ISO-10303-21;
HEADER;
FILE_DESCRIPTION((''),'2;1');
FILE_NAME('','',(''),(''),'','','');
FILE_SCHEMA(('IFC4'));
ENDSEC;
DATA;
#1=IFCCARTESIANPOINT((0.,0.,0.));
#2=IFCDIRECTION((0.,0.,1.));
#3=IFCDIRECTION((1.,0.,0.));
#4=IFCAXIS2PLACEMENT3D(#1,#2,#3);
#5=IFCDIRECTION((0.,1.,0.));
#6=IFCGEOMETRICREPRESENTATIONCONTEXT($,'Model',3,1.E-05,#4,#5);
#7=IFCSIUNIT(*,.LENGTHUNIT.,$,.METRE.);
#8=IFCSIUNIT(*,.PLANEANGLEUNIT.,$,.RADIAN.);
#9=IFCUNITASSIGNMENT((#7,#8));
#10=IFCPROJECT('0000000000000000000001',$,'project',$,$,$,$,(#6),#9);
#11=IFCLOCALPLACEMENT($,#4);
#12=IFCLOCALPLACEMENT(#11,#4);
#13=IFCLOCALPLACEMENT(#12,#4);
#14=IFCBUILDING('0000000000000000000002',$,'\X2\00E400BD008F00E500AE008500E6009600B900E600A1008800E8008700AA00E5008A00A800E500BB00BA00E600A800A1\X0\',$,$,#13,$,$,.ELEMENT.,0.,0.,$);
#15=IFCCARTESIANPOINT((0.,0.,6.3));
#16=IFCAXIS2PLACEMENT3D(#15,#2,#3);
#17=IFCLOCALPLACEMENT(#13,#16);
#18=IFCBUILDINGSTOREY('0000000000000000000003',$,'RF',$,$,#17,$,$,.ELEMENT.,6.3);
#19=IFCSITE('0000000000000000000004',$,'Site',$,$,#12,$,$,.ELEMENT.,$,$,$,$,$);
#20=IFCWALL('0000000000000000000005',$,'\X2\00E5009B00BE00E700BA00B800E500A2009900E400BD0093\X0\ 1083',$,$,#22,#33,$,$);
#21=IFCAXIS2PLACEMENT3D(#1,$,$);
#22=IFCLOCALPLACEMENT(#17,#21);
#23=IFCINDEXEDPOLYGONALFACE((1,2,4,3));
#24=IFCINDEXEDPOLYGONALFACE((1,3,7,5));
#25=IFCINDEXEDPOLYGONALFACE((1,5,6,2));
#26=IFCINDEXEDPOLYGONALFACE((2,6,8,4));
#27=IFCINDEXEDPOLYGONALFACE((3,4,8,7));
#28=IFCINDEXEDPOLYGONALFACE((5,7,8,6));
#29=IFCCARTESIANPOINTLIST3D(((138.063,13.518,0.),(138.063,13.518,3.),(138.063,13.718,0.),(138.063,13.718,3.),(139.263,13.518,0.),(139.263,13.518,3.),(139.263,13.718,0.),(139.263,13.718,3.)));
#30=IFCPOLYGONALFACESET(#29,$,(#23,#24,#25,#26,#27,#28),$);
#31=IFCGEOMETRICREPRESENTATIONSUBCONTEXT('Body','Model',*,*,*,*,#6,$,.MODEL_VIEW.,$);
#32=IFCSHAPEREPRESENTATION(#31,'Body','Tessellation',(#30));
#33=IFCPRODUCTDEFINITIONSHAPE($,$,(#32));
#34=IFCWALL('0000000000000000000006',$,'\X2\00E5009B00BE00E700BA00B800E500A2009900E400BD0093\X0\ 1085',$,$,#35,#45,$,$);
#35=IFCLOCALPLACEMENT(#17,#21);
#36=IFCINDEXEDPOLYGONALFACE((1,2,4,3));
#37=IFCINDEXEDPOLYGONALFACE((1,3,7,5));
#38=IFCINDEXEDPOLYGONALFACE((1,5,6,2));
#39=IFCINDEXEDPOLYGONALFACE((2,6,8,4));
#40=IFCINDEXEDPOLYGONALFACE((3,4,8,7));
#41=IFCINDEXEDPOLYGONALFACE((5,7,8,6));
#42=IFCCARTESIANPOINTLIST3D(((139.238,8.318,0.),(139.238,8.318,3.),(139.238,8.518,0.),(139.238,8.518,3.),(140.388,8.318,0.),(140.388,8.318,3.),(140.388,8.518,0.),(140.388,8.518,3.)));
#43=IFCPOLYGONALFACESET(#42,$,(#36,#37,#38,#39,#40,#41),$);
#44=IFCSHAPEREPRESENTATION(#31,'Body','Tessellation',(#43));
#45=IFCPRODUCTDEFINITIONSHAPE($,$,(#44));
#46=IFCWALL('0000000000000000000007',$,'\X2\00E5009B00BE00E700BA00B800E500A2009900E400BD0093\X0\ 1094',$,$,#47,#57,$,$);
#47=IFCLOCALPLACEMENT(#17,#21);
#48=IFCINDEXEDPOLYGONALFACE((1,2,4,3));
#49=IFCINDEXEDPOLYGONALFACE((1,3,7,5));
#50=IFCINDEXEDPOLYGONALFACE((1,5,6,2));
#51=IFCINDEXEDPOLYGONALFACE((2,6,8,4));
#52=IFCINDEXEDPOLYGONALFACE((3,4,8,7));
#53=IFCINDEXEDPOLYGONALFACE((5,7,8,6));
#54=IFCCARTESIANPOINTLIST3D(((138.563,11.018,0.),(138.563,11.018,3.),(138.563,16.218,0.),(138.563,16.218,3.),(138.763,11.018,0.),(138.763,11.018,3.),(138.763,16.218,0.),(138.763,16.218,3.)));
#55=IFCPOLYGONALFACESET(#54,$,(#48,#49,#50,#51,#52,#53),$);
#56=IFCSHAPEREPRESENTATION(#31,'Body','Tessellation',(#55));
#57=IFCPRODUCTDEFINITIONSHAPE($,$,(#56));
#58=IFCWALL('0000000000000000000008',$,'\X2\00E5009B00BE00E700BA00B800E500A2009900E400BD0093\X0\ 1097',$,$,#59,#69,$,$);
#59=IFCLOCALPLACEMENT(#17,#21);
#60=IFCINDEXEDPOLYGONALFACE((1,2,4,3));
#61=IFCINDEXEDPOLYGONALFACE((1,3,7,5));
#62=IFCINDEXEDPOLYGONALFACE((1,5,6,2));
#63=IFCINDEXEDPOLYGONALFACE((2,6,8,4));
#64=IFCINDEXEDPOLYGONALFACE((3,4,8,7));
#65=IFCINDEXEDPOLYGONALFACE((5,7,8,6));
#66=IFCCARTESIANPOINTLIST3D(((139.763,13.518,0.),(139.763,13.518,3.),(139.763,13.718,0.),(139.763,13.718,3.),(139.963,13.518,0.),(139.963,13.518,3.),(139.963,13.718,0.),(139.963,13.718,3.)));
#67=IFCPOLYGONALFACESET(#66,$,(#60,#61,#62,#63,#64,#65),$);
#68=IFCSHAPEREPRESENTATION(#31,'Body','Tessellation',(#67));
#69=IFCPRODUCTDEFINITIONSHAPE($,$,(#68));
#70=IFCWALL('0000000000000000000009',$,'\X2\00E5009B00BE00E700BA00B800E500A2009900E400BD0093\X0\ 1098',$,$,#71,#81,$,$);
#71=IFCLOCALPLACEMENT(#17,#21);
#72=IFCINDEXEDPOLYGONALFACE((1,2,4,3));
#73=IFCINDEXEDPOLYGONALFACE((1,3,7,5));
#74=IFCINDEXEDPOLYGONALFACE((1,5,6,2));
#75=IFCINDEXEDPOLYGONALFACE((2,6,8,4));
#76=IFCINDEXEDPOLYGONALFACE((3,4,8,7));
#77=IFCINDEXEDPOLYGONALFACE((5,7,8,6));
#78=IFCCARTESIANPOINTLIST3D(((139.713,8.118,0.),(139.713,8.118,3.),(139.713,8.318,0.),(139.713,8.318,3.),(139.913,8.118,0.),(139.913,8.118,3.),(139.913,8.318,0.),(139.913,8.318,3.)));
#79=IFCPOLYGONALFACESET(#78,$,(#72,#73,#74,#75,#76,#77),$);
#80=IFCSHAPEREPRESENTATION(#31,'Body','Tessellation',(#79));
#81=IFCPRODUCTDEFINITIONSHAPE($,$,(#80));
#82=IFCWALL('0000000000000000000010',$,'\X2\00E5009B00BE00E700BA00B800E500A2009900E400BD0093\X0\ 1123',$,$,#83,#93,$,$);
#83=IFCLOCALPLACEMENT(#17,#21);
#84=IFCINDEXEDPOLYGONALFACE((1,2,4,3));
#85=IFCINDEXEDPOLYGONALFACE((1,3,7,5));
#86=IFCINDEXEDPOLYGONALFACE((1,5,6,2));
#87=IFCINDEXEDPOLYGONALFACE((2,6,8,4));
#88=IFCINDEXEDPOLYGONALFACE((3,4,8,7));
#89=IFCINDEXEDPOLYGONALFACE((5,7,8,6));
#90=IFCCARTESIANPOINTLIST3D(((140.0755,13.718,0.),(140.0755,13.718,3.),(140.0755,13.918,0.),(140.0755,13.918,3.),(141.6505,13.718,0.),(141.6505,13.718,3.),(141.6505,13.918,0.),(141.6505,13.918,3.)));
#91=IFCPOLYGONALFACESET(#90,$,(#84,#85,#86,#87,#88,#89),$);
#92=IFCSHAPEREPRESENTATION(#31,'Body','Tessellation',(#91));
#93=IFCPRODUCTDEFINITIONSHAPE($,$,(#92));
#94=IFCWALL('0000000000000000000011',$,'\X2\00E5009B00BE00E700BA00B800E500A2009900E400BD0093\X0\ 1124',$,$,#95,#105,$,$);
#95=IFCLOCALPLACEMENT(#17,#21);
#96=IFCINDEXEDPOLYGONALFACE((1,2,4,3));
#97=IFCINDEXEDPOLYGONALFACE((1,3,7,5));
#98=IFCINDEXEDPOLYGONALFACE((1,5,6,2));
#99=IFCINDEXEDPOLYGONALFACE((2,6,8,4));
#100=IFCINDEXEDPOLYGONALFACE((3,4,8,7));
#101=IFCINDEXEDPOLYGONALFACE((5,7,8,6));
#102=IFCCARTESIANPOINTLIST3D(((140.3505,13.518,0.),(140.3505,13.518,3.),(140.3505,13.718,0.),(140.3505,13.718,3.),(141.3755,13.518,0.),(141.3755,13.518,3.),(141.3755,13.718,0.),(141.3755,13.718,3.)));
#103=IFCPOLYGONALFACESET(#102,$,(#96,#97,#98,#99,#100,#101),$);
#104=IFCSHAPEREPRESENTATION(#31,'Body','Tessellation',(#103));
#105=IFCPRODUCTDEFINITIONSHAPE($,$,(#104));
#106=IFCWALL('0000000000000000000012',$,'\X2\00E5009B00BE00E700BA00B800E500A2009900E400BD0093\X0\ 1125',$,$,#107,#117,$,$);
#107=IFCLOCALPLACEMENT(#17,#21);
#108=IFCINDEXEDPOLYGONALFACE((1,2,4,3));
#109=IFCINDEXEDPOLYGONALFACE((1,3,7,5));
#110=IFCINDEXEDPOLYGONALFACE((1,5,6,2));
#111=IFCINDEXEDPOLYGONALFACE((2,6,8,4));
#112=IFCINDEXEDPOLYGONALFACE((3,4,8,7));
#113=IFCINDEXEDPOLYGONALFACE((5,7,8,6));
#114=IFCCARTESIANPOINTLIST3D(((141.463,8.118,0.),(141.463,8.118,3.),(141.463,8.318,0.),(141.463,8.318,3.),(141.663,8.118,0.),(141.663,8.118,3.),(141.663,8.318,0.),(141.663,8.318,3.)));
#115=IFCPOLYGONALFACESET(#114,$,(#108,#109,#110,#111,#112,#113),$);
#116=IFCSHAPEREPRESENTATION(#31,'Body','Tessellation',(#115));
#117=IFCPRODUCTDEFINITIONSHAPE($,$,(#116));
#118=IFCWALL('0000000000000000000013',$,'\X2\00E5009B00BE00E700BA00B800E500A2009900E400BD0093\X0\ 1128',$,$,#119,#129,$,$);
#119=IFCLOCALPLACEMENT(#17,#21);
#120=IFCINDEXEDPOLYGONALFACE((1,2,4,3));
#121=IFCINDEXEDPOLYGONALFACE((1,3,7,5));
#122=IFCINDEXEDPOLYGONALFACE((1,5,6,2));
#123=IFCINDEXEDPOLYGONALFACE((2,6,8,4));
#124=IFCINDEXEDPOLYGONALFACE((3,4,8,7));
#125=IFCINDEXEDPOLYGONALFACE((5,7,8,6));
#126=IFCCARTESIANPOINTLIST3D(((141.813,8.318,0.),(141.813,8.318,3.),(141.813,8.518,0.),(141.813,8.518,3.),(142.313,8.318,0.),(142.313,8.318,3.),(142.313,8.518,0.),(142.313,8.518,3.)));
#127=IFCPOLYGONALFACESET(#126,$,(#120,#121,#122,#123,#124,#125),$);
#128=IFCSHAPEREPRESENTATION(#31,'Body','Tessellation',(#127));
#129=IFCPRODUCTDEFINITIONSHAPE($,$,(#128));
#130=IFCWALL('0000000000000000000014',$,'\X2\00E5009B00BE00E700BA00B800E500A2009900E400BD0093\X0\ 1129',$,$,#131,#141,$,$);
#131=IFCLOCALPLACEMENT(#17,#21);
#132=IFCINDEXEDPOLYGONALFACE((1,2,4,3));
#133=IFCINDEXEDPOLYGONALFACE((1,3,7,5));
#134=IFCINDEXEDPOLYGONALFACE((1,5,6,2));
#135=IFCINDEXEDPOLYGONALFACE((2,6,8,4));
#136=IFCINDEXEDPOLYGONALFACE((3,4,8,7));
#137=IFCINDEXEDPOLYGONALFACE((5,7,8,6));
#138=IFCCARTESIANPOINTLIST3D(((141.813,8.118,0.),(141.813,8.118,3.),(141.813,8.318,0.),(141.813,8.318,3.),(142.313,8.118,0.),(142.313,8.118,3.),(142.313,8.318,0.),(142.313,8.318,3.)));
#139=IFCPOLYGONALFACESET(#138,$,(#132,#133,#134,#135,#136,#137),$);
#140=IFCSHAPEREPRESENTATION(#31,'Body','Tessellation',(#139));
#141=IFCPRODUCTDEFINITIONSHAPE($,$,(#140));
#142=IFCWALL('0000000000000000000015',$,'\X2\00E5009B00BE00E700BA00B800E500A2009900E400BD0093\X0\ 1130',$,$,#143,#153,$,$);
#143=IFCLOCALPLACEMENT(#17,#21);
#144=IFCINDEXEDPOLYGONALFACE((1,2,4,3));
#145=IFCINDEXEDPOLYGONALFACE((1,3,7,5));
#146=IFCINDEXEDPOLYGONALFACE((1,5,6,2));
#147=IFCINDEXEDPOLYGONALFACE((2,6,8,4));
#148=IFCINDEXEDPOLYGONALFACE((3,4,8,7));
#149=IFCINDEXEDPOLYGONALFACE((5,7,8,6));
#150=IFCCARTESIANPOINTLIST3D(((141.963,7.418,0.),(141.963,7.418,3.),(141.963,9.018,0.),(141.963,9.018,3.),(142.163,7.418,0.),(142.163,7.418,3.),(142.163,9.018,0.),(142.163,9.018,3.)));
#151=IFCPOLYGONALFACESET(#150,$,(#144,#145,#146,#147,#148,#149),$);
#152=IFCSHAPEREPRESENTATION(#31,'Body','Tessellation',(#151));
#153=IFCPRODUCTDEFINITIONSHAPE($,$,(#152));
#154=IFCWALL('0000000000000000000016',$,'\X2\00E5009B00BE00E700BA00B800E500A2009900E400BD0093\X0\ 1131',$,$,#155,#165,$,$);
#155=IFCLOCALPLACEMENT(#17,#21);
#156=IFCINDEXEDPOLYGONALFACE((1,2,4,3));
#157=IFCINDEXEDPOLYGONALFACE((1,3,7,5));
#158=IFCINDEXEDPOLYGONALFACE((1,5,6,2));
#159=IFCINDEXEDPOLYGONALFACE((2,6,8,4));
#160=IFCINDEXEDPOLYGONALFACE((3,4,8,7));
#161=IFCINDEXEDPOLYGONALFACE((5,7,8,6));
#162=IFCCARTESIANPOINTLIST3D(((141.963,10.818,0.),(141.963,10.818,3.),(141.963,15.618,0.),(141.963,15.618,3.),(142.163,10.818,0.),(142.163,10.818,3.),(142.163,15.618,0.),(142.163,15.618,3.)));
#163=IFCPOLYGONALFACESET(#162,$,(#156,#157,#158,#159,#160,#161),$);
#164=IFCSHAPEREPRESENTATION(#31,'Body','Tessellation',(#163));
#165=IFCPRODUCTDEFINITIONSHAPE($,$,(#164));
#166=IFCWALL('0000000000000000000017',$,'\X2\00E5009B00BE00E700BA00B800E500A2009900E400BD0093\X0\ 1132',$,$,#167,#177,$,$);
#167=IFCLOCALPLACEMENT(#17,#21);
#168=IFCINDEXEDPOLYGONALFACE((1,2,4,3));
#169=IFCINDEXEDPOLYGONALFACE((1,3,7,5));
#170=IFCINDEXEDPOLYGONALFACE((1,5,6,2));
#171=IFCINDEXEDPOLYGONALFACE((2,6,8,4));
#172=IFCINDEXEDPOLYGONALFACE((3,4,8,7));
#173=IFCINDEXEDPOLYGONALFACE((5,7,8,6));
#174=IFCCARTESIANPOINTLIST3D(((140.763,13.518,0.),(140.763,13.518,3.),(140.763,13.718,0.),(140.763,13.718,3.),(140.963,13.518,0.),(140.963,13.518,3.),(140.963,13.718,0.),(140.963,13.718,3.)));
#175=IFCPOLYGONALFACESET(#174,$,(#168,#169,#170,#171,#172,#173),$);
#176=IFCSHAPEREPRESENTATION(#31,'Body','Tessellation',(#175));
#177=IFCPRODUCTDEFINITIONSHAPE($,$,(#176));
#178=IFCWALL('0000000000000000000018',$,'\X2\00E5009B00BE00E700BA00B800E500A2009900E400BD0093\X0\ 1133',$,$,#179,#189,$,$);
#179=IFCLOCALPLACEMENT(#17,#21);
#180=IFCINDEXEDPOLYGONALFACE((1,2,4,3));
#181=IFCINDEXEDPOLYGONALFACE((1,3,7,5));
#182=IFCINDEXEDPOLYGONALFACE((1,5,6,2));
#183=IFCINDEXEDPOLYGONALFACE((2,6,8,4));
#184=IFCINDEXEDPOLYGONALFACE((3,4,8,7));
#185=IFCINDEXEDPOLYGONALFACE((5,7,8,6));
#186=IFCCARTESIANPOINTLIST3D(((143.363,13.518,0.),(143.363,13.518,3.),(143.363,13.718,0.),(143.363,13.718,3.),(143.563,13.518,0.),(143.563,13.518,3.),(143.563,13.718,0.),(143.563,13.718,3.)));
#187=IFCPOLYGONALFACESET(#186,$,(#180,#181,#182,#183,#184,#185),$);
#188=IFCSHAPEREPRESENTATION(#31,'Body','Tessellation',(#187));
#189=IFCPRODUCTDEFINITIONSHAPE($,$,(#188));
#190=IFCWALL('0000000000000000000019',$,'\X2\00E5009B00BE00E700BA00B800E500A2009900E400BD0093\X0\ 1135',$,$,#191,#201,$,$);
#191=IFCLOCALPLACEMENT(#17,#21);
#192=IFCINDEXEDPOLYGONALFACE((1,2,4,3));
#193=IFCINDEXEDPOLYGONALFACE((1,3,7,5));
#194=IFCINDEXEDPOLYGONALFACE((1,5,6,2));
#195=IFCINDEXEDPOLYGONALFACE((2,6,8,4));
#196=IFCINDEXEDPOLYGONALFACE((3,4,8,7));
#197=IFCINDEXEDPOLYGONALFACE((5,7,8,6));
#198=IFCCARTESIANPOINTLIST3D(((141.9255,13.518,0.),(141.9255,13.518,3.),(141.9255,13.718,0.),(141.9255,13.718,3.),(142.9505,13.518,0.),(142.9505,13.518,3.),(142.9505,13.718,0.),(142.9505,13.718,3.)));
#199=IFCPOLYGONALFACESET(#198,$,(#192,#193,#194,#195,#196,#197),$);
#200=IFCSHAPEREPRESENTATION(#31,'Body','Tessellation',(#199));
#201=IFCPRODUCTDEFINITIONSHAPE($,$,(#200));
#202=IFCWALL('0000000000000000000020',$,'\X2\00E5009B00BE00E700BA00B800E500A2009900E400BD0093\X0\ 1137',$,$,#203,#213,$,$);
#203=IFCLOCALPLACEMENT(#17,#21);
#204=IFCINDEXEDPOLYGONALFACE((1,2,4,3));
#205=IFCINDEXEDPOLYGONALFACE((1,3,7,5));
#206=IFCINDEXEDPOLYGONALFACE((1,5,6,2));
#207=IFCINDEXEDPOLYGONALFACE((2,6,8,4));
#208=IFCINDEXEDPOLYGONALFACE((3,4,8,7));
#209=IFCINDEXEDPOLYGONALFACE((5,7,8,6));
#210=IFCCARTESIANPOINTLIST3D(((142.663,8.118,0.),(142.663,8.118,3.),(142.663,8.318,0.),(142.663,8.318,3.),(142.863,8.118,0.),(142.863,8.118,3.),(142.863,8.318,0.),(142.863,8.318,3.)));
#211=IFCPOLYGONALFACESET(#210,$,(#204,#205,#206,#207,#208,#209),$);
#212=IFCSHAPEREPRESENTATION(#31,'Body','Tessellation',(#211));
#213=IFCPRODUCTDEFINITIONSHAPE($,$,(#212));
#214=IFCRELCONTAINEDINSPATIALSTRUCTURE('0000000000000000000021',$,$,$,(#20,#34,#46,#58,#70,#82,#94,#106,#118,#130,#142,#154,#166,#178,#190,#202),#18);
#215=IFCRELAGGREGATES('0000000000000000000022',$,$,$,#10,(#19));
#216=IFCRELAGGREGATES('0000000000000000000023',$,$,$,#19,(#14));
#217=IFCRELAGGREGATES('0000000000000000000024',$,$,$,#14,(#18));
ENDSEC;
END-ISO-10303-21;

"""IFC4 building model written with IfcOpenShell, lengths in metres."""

from ifc_helpers import new_model, si_unit, direction, frame, frame_2d, origin_with_axes, place, context, subcontext, project, spatial, rectangle, extrude, element, save


model = new_model("IFC4")

# Units and contexts
model_context = context("Model", 3, precision=1e-05, world=origin_with_axes(), true_north=direction((0.0, 1.0, 0.0)))
body_context = subcontext(model_context, "Body", "Model", "MODEL_VIEW")
ifc_project = project(units=[si_unit("LENGTHUNIT", "METRE"), si_unit("PLANEANGLEUNIT", "RADIAN")], contexts=[model_context])

# Site, building, storey
placement = place(None, origin_with_axes())
site_placement = place(placement, origin_with_axes())
site = spatial("IfcSite", under=ifc_project, at=site_placement, Name="Site", CompositionType="ELEMENT")
building_placement = place(site_placement, origin_with_axes())
building = spatial("IfcBuilding", under=site, at=building_placement, Name="ä½\u008få®\u0085æ\u0096¹æ¡\u0088è\u0087ªå\u008a¨å»ºæ¨¡", CompositionType="ELEMENT", ElevationOfRefHeight=0.0, ElevationOfTerrain=0.0)
storey_placement = place(building_placement, frame((0.0, 0.0, 6.3), z_axis=(0.0, 0.0, 1.0), x_axis=(1.0, 0.0, 0.0)))
storey = spatial("IfcBuildingStorey", under=building, at=storey_placement, Name="RF", CompositionType="ELEMENT", Elevation=6.3)

# Walls
wall_1_placement = place(storey_placement, frame((138.663, 13.618, 0.0), z_axis=(0.0, 0.0, 1.0), x_axis=(1.0, 0.0, 0.0)))
element("IfcWall", 1, at=wall_1_placement, inside=storey, Name="å\u009b¾çº¸å¢\u0099ä½\u0093 1083", context=body_context, shape_type="SweptSolid", body=[
    extrude(rectangle(XDim=1.2, YDim=0.2, at=frame_2d((0.0, 0.0), x_axis=(1.0, 0.0, 0.0))), frame((0.0, 0.0, 0.0), z_axis=(0.0, 0.0, 1.0)), (0.0, 0.0, 1.0), 3.0),
])
wall_2_placement = place(storey_placement, frame((139.813, 8.418, 0.0), z_axis=(0.0, 0.0, 1.0), x_axis=(-1.0, 0.0, 0.0)))
element("IfcWall", 2, at=wall_2_placement, inside=storey, Name="å\u009b¾çº¸å¢\u0099ä½\u0093 1085", context=body_context, shape_type="SweptSolid", body=[
    extrude(rectangle(XDim=1.15, YDim=0.2, at=frame_2d((0.0, 0.0), x_axis=(1.0, 0.0, 0.0))), frame((0.0, 0.0, 0.0), z_axis=(0.0, 0.0, 1.0)), (0.0, 0.0, 1.0), 3.0),
])
wall_3_placement = place(storey_placement, frame((138.663, 13.618, 0.0), z_axis=(0.0, 0.0, 1.0), x_axis=(0.0, -1.0, 0.0)))
element("IfcWall", 3, at=wall_3_placement, inside=storey, Name="å\u009b¾çº¸å¢\u0099ä½\u0093 1094", context=body_context, shape_type="SweptSolid", body=[
    extrude(rectangle(XDim=5.2, YDim=0.2, at=frame_2d((0.0, 0.0), x_axis=(1.0, 0.0, 0.0))), frame((0.0, 0.0, 0.0), z_axis=(0.0, 0.0, 1.0)), (0.0, 0.0, 1.0), 3.0),
])
for number, where, z_axis, x_axis, name in (
    (4, (139.863, 13.618, 0.0), (0.0, 0.0, 1.0), (0.0, 1.0, 0.0), "å\u009b¾çº¸å¢\u0099ä½\u0093 1097"),
    (5, (139.813, 8.218, 0.0), (0.0, 0.0, 1.0), (0.0, 1.0, 0.0), "å\u009b¾çº¸å¢\u0099ä½\u0093 1098"),
):
    element("IfcWall", number, at=place(storey_placement, frame(where, z_axis=z_axis, x_axis=x_axis)), inside=storey, Name=name, context=body_context, shape_type="SweptSolid", body=[
        extrude(rectangle(XDim=0.2, YDim=0.2, at=frame_2d((0.0, 0.0), x_axis=(1.0, 0.0, 0.0))), frame((0.0, 0.0, 0.0), z_axis=(0.0, 0.0, 1.0)), (0.0, 0.0, 1.0), 3.0),
    ])
wall_4_placement = place(storey_placement, frame((140.863, 13.818, 0.0), z_axis=(0.0, 0.0, 1.0), x_axis=(1.0, 0.0, 0.0)))
element("IfcWall", 6, at=wall_4_placement, inside=storey, Name="å\u009b¾çº¸å¢\u0099ä½\u0093 1123", context=body_context, shape_type="SweptSolid", body=[
    extrude(rectangle(XDim=1.575, YDim=0.2, at=frame_2d((0.0, 0.0), x_axis=(1.0, 0.0, 0.0))), frame((0.0, 0.0, 0.0), z_axis=(0.0, 0.0, 1.0)), (0.0, 0.0, 1.0), 3.0),
])
wall_5_placement = place(storey_placement, frame((140.863, 13.618, 0.0), z_axis=(0.0, 0.0, 1.0), x_axis=(1.0, 0.0, 0.0)))
element("IfcWall", 7, at=wall_5_placement, inside=storey, Name="å\u009b¾çº¸å¢\u0099ä½\u0093 1124", context=body_context, shape_type="SweptSolid", body=[
    extrude(rectangle(XDim=1.025, YDim=0.2, at=frame_2d((0.0, 0.0), x_axis=(1.0, 0.0, 0.0))), frame((0.0, 0.0, 0.0), z_axis=(0.0, 0.0, 1.0)), (0.0, 0.0, 1.0), 3.0),
])
wall_6_placement = place(storey_placement, frame((141.563, 8.218, 0.0), z_axis=(0.0, 0.0, 1.0), x_axis=(0.0, 1.0, 0.0)))
element("IfcWall", 8, at=wall_6_placement, inside=storey, Name="å\u009b¾çº¸å¢\u0099ä½\u0093 1125", context=body_context, shape_type="SweptSolid", body=[
    extrude(rectangle(XDim=0.2, YDim=0.2, at=frame_2d((0.0, 0.0), x_axis=(1.0, 0.0, 0.0))), frame((0.0, 0.0, 0.0), z_axis=(0.0, 0.0, 1.0)), (0.0, 0.0, 1.0), 3.0),
])
for number, where, z_axis, x_axis, name in (
    (9, (142.063, 8.418, 0.0), (0.0, 0.0, 1.0), (-1.0, 0.0, 0.0), "å\u009b¾çº¸å¢\u0099ä½\u0093 1128"),
    (10, (142.063, 8.218, 0.0), (0.0, 0.0, 1.0), (-1.0, 0.0, 0.0), "å\u009b¾çº¸å¢\u0099ä½\u0093 1129"),
):
    element("IfcWall", number, at=place(storey_placement, frame(where, z_axis=z_axis, x_axis=x_axis)), inside=storey, Name=name, context=body_context, shape_type="SweptSolid", body=[
        extrude(rectangle(XDim=0.5, YDim=0.2, at=frame_2d((0.0, 0.0), x_axis=(1.0, 0.0, 0.0))), frame((0.0, 0.0, 0.0), z_axis=(0.0, 0.0, 1.0)), (0.0, 0.0, 1.0), 3.0),
    ])
wall_7_placement = place(storey_placement, frame((142.063, 8.218, 0.0), z_axis=(0.0, 0.0, 1.0), x_axis=(0.0, -1.0, 0.0)))
element("IfcWall", 11, at=wall_7_placement, inside=storey, Name="å\u009b¾çº¸å¢\u0099ä½\u0093 1130", context=body_context, shape_type="SweptSolid", body=[
    extrude(rectangle(XDim=1.6, YDim=0.2, at=frame_2d((0.0, 0.0), x_axis=(1.0, 0.0, 0.0))), frame((0.0, 0.0, 0.0), z_axis=(0.0, 0.0, 1.0)), (0.0, 0.0, 1.0), 3.0),
])
wall_8_placement = place(storey_placement, frame((142.063, 13.218, 0.0), z_axis=(0.0, 0.0, 1.0), x_axis=(0.0, -1.0, 0.0)))
element("IfcWall", 12, at=wall_8_placement, inside=storey, Name="å\u009b¾çº¸å¢\u0099ä½\u0093 1131", context=body_context, shape_type="SweptSolid", body=[
    extrude(rectangle(XDim=4.8, YDim=0.2, at=frame_2d((0.0, 0.0), x_axis=(1.0, 0.0, 0.0))), frame((0.0, 0.0, 0.0), z_axis=(0.0, 0.0, 1.0)), (0.0, 0.0, 1.0), 3.0),
])
for number, where, z_axis, x_axis, name in (
    (13, (140.863, 13.618, 0.0), (0.0, 0.0, 1.0), (0.0, 1.0, 0.0), "å\u009b¾çº¸å¢\u0099ä½\u0093 1132"),
    (14, (143.463, 13.618, 0.0), (0.0, 0.0, 1.0), (0.0, 1.0, 0.0), "å\u009b¾çº¸å¢\u0099ä½\u0093 1133"),
):
    element("IfcWall", number, at=place(storey_placement, frame(where, z_axis=z_axis, x_axis=x_axis)), inside=storey, Name=name, context=body_context, shape_type="SweptSolid", body=[
        extrude(rectangle(XDim=0.2, YDim=0.2, at=frame_2d((0.0, 0.0), x_axis=(1.0, 0.0, 0.0))), frame((0.0, 0.0, 0.0), z_axis=(0.0, 0.0, 1.0)), (0.0, 0.0, 1.0), 3.0),
    ])
wall_9_placement = place(storey_placement, frame((142.438, 13.618, 0.0), z_axis=(0.0, 0.0, 1.0), x_axis=(1.0, 0.0, 0.0)))
element("IfcWall", 15, at=wall_9_placement, inside=storey, Name="å\u009b¾çº¸å¢\u0099ä½\u0093 1135", context=body_context, shape_type="SweptSolid", body=[
    extrude(rectangle(XDim=1.025, YDim=0.2, at=frame_2d((0.0, 0.0), x_axis=(1.0, 0.0, 0.0))), frame((0.0, 0.0, 0.0), z_axis=(0.0, 0.0, 1.0)), (0.0, 0.0, 1.0), 3.0),
])
wall_10_placement = place(storey_placement, frame((142.763, 8.218, 0.0), z_axis=(0.0, 0.0, 1.0), x_axis=(0.0, 1.0, 0.0)))
element("IfcWall", 16, at=wall_10_placement, inside=storey, Name="å\u009b¾çº¸å¢\u0099ä½\u0093 1137", context=body_context, shape_type="SweptSolid", body=[
    extrude(rectangle(XDim=0.2, YDim=0.2, at=frame_2d((0.0, 0.0), x_axis=(1.0, 0.0, 0.0))), frame((0.0, 0.0, 0.0), z_axis=(0.0, 0.0, 1.0)), (0.0, 0.0, 1.0), 3.0),
])

save(model, "model.ifc")
